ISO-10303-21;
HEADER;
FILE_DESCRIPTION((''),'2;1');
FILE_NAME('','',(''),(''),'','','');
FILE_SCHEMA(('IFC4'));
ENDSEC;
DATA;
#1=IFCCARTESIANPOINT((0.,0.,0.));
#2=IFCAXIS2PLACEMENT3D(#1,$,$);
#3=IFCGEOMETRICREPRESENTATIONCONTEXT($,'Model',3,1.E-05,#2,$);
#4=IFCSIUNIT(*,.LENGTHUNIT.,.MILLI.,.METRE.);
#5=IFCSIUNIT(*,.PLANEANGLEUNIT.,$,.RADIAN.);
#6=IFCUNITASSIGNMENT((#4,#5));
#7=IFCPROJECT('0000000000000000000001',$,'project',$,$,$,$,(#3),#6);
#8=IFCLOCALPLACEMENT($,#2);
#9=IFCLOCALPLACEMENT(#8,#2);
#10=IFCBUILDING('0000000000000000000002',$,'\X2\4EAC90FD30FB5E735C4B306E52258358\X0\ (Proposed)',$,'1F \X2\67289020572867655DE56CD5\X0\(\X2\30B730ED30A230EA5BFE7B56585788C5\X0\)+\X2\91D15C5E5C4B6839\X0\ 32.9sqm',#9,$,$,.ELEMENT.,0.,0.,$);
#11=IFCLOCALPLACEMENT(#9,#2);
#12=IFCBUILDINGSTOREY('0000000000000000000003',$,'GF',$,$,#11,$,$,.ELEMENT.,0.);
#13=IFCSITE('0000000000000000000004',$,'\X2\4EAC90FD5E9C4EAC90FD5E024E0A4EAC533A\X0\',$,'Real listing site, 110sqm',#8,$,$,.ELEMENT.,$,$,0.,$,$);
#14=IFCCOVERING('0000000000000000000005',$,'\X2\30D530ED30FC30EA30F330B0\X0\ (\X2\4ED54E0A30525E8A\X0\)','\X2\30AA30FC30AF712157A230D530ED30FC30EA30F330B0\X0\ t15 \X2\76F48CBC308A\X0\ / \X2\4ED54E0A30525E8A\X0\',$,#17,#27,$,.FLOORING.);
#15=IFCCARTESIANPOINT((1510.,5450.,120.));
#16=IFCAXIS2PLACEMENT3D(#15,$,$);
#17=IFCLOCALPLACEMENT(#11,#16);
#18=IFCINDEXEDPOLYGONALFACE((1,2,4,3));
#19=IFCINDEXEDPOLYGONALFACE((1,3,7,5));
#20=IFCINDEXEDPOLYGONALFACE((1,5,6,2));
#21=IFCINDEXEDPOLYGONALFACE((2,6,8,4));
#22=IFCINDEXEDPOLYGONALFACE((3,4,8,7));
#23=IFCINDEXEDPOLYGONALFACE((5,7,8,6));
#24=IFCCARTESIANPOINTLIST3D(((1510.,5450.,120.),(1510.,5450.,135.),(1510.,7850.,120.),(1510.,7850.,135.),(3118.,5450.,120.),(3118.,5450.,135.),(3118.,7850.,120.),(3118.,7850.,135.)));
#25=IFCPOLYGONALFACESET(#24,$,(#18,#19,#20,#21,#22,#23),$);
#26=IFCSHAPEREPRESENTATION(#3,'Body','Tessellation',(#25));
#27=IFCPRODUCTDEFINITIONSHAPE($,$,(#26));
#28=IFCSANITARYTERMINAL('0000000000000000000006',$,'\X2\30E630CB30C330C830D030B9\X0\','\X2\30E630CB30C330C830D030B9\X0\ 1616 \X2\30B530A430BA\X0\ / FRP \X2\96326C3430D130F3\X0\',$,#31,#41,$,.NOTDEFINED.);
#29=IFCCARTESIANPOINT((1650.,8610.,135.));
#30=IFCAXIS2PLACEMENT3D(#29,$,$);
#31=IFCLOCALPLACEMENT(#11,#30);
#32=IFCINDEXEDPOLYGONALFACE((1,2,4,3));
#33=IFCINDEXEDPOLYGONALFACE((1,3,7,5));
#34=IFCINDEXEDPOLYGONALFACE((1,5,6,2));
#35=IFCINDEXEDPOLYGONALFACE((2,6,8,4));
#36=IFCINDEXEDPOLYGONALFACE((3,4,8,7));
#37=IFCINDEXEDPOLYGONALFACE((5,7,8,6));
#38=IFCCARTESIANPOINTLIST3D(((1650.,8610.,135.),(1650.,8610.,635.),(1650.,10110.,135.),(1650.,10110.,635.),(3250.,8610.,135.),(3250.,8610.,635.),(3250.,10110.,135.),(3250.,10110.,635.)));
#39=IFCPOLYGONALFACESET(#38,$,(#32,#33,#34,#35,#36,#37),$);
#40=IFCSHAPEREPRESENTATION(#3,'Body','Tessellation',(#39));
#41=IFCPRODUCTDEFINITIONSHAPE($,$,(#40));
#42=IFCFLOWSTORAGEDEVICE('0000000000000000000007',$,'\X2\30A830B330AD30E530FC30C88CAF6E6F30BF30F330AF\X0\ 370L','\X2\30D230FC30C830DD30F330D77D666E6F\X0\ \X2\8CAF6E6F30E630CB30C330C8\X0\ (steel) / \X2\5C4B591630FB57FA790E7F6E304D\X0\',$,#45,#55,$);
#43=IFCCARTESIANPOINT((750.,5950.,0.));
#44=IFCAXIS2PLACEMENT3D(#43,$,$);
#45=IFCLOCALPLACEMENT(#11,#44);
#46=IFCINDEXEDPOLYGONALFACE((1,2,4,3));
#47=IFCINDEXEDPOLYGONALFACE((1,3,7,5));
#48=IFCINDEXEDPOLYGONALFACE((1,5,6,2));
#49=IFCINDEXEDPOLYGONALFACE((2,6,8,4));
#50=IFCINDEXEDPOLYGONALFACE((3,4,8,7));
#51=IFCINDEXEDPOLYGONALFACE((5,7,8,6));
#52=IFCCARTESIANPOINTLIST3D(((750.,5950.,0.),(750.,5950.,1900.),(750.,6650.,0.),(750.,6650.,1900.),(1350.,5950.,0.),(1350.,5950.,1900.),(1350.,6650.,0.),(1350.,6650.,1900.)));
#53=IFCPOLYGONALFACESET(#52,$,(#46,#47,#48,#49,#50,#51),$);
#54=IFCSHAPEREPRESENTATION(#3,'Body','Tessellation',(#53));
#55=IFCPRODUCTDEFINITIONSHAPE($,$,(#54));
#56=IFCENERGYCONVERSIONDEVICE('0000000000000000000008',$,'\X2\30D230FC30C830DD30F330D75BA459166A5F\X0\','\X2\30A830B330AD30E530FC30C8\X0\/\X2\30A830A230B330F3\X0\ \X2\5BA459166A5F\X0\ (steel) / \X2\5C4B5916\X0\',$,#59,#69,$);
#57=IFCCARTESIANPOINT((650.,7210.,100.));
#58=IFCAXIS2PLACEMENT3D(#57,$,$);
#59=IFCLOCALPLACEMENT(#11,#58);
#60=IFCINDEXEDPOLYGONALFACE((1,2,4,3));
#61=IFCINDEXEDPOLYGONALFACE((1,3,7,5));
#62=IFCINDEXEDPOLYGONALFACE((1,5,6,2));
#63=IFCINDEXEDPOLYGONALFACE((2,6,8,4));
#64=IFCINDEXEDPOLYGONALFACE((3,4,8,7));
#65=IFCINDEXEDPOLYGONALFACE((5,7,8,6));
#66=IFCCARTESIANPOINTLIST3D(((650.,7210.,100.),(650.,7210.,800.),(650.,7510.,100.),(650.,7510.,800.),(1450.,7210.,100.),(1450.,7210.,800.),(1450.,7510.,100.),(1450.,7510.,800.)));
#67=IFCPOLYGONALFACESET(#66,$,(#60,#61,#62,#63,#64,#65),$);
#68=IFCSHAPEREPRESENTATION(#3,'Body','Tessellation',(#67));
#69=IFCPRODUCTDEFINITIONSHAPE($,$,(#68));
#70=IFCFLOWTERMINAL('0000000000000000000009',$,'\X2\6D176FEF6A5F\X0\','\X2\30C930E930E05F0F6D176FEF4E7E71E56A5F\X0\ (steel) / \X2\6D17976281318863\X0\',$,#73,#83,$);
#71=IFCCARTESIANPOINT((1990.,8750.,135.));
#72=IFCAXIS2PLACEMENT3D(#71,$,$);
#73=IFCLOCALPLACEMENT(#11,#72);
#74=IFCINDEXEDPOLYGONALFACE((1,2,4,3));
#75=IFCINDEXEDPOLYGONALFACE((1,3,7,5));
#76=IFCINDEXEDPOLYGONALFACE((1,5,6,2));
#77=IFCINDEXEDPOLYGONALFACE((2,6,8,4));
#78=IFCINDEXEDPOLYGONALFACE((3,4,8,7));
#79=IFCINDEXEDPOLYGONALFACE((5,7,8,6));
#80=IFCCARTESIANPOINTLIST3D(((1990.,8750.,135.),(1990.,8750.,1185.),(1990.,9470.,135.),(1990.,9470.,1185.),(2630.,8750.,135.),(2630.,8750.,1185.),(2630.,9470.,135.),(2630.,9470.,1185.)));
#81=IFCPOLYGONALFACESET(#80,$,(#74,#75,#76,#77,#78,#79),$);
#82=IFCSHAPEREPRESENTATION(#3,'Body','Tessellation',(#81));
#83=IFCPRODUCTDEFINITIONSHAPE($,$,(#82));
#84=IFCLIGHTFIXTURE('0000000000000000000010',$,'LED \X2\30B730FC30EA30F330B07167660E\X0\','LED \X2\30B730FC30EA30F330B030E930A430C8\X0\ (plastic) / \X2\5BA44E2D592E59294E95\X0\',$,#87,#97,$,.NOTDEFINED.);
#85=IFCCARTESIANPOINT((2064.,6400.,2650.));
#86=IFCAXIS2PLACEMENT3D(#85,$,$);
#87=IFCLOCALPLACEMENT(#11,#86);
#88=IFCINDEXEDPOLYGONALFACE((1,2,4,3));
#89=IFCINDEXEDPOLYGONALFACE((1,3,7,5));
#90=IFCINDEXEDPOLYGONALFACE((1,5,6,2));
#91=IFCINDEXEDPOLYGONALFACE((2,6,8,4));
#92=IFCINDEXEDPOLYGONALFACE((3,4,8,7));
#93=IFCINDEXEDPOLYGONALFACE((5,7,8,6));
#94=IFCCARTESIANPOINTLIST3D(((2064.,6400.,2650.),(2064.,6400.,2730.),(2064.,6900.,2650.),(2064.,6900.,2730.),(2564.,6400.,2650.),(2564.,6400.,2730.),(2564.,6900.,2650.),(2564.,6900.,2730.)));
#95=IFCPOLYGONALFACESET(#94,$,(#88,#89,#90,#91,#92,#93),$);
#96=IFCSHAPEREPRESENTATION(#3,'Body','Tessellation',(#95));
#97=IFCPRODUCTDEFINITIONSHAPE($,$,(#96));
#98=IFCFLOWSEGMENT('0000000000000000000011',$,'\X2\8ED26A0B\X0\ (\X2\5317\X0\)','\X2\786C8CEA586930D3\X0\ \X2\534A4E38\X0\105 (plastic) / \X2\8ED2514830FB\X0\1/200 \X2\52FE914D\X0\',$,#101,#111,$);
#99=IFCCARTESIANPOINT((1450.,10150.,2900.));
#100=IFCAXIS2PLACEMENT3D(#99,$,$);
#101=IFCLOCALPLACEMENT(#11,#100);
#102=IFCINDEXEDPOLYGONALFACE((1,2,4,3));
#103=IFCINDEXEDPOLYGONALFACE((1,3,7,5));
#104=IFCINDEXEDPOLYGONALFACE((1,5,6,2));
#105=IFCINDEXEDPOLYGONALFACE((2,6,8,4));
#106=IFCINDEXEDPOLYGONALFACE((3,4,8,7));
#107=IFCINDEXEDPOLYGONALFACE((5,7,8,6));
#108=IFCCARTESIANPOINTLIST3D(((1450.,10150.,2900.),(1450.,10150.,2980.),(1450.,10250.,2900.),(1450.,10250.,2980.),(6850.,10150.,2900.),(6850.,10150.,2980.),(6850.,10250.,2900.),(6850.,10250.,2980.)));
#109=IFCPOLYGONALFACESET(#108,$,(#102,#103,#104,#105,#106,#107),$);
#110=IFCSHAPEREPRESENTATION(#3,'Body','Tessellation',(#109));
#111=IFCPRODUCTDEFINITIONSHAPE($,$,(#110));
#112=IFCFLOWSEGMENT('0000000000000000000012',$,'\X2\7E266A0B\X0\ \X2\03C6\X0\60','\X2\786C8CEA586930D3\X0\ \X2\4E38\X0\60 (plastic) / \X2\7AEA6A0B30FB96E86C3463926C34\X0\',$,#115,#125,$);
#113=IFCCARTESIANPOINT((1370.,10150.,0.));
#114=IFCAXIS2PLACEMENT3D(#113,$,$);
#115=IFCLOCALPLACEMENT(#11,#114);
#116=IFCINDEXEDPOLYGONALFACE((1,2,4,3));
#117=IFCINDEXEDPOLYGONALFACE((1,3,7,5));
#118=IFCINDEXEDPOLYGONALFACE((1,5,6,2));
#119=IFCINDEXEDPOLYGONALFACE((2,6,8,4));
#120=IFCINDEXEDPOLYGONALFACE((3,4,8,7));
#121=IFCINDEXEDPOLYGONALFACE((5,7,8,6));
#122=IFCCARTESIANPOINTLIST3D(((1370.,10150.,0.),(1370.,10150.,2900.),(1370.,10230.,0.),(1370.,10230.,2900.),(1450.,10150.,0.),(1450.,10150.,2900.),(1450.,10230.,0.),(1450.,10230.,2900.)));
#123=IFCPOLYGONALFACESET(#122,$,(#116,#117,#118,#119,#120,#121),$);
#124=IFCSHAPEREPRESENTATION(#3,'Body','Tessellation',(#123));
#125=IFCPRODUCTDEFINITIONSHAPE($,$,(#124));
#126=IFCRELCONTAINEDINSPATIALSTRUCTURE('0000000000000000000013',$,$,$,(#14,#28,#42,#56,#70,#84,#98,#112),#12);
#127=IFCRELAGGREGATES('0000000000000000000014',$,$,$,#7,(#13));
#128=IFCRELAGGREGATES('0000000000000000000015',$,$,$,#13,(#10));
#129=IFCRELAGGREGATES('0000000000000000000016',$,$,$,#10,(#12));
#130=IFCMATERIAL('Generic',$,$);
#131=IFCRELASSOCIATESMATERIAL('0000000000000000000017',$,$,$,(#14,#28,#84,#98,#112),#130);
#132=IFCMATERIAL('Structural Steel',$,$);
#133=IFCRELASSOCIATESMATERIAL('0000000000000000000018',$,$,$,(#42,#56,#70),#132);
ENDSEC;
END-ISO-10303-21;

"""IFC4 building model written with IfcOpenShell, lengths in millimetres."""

from ifc_helpers import new_model, si_unit, frame, frame_2d, origin, place, context, project, spatial, rectangle, extrude, material, element, save


model = new_model("IFC4")

# Units and contexts
model_context = context("Model", 3, precision=1e-05, world=origin())
ifc_project = project(units=[si_unit("LENGTHUNIT", "METRE", prefix="MILLI"), si_unit("PLANEANGLEUNIT", "RADIAN")], contexts=[model_context])

# Site, building, storey
site_placement = place(None, origin())
site = spatial("IfcSite", under=ifc_project, at=site_placement, Name="京都府京都市上京区", ObjectType="Real listing site, 110sqm", CompositionType="ELEMENT", RefElevation=0.0)
building_placement = place(site_placement, origin())
building = spatial("IfcBuilding", under=site, at=building_placement, Name="京都・平屋の別荘 (Proposed)", ObjectType="1F 木造在来工法(シロアリ対策塗装)+金属屋根 32.9sqm", CompositionType="ELEMENT", ElevationOfRefHeight=0.0, ElevationOfTerrain=0.0)
storey_placement = place(building_placement, origin())
storey = spatial("IfcBuildingStorey", under=building, at=storey_placement, Name="GF", CompositionType="ELEMENT", Elevation=0.0)

# Shared definitions
ifc_material_1 = material(Name="Structural Steel")

# Covering
ifc_material_2 = material(Name="Generic")
covering_1_placement = place(storey_placement, frame((1510.0, 5450.0, 120.0)))
element("IfcCovering", 1, at=covering_1_placement, inside=storey, material=ifc_material_2, Name="フローリング (仕上げ床)", Description="オーク無垢フローリング t15 直貼り / 仕上げ床", PredefinedType="FLOORING", context=model_context, shape_type="SweptSolid", body=[
    extrude(rectangle(XDim=1608.0, YDim=2400.0, at=frame_2d((804.0, 1200.0))), frame((1510.0, 5450.0, 120.0)), (0.0, 0.0, 1.0), 15.0),
])

# Sanitary terminal
sanitary_terminal_placement = place(storey_placement, frame((1650.0, 8610.0, 135.0)))
element("IfcSanitaryTerminal", 2, at=sanitary_terminal_placement, inside=storey, material=ifc_material_2, Name="ユニットバス", Description="ユニットバス 1616 サイズ / FRP 防水パン", PredefinedType="NOTDEFINED", context=model_context, shape_type="SweptSolid", body=[
    extrude(rectangle(XDim=1600.0, YDim=1500.0, at=frame_2d((800.0, 750.0))), frame((1650.0, 8610.0, 135.0)), (0.0, 0.0, 1.0), 500.0),
])

# Flow storage device
flow_storage_device_placement = place(storey_placement, frame((750.0, 5950.0, 0.0)))
element("IfcFlowStorageDevice", 3, at=flow_storage_device_placement, inside=storey, material=ifc_material_1, Name="エコキュート貯湯タンク 370L", Description="ヒートポンプ給湯 貯湯ユニット (steel) / 屋外・基礎置き", context=model_context, shape_type="SweptSolid", body=[
    extrude(rectangle(XDim=600.0, YDim=700.0, at=frame_2d((300.0, 350.0))), frame((750.0, 5950.0, 0.0)), (0.0, 0.0, 1.0), 1900.0),
])

# Energy conversion device
energy_conversion_device_placement = place(storey_placement, frame((650.0, 7210.0, 100.0)))
element("IfcEnergyConversionDevice", 4, at=energy_conversion_device_placement, inside=storey, material=ifc_material_1, Name="ヒートポンプ室外機", Description="エコキュート/エアコン 室外機 (steel) / 屋外", context=model_context, shape_type="SweptSolid", body=[
    extrude(rectangle(XDim=800.0, YDim=300.0, at=frame_2d((400.0, 150.0))), frame((650.0, 7210.0, 100.0)), (0.0, 0.0, 1.0), 700.0),
])

# Flow terminal
flow_terminal_placement = place(storey_placement, frame((1990.0, 8750.0, 135.0)))
element("IfcFlowTerminal", 5, at=flow_terminal_placement, inside=storey, material=ifc_material_1, Name="洗濯機", Description="ドラム式洗濯乾燥機 (steel) / 洗面脱衣", context=model_context, shape_type="SweptSolid", body=[
    extrude(rectangle(XDim=640.0, YDim=720.0, at=frame_2d((320.0, 360.0))), frame((1990.0, 8750.0, 135.0)), (0.0, 0.0, 1.0), 1050.0),
])

# Light fixture
light_fixture_placement = place(storey_placement, frame((2064.0, 6400.0, 2650.0)))
element("IfcLightFixture", 6, at=light_fixture_placement, inside=storey, material=ifc_material_2, Name="LED シーリング照明", Description="LED シーリングライト (plastic) / 室中央天井", PredefinedType="NOTDEFINED", context=model_context, shape_type="SweptSolid", body=[
    extrude(rectangle(XDim=500.0, YDim=500.0, at=frame_2d((250.0, 250.0))), frame((2064.0, 6400.0, 2650.0)), (0.0, 0.0, 1.0), 80.0),
])

# Flow segments
flow_segment_1_placement = place(storey_placement, frame((1450.0, 10150.0, 2900.0)))
element("IfcFlowSegment", 7, at=flow_segment_1_placement, inside=storey, material=ifc_material_2, Name="軒樋 (北)", Description="硬質塩ビ 半丸105 (plastic) / 軒先・1/200 勾配", context=model_context, shape_type="SweptSolid", body=[
    extrude(rectangle(XDim=5400.0, YDim=100.0, at=frame_2d((2700.0, 50.0))), frame((1450.0, 10150.0, 2900.0)), (0.0, 0.0, 1.0), 80.0),
])
flow_segment_2_placement = place(storey_placement, frame((1370.0, 10150.0, 0.0)))
element("IfcFlowSegment", 8, at=flow_segment_2_placement, inside=storey, material=ifc_material_2, Name="縦樋 φ60", Description="硬質塩ビ 丸60 (plastic) / 竪樋・雨水排水", context=model_context, shape_type="SweptSolid", body=[
    extrude(rectangle(XDim=80.0, YDim=80.0, at=frame_2d((40.0, 40.0))), frame((1370.0, 10150.0, 0.0)), (0.0, 0.0, 1.0), 2900.0),
])

save(model, "model.ifc")
